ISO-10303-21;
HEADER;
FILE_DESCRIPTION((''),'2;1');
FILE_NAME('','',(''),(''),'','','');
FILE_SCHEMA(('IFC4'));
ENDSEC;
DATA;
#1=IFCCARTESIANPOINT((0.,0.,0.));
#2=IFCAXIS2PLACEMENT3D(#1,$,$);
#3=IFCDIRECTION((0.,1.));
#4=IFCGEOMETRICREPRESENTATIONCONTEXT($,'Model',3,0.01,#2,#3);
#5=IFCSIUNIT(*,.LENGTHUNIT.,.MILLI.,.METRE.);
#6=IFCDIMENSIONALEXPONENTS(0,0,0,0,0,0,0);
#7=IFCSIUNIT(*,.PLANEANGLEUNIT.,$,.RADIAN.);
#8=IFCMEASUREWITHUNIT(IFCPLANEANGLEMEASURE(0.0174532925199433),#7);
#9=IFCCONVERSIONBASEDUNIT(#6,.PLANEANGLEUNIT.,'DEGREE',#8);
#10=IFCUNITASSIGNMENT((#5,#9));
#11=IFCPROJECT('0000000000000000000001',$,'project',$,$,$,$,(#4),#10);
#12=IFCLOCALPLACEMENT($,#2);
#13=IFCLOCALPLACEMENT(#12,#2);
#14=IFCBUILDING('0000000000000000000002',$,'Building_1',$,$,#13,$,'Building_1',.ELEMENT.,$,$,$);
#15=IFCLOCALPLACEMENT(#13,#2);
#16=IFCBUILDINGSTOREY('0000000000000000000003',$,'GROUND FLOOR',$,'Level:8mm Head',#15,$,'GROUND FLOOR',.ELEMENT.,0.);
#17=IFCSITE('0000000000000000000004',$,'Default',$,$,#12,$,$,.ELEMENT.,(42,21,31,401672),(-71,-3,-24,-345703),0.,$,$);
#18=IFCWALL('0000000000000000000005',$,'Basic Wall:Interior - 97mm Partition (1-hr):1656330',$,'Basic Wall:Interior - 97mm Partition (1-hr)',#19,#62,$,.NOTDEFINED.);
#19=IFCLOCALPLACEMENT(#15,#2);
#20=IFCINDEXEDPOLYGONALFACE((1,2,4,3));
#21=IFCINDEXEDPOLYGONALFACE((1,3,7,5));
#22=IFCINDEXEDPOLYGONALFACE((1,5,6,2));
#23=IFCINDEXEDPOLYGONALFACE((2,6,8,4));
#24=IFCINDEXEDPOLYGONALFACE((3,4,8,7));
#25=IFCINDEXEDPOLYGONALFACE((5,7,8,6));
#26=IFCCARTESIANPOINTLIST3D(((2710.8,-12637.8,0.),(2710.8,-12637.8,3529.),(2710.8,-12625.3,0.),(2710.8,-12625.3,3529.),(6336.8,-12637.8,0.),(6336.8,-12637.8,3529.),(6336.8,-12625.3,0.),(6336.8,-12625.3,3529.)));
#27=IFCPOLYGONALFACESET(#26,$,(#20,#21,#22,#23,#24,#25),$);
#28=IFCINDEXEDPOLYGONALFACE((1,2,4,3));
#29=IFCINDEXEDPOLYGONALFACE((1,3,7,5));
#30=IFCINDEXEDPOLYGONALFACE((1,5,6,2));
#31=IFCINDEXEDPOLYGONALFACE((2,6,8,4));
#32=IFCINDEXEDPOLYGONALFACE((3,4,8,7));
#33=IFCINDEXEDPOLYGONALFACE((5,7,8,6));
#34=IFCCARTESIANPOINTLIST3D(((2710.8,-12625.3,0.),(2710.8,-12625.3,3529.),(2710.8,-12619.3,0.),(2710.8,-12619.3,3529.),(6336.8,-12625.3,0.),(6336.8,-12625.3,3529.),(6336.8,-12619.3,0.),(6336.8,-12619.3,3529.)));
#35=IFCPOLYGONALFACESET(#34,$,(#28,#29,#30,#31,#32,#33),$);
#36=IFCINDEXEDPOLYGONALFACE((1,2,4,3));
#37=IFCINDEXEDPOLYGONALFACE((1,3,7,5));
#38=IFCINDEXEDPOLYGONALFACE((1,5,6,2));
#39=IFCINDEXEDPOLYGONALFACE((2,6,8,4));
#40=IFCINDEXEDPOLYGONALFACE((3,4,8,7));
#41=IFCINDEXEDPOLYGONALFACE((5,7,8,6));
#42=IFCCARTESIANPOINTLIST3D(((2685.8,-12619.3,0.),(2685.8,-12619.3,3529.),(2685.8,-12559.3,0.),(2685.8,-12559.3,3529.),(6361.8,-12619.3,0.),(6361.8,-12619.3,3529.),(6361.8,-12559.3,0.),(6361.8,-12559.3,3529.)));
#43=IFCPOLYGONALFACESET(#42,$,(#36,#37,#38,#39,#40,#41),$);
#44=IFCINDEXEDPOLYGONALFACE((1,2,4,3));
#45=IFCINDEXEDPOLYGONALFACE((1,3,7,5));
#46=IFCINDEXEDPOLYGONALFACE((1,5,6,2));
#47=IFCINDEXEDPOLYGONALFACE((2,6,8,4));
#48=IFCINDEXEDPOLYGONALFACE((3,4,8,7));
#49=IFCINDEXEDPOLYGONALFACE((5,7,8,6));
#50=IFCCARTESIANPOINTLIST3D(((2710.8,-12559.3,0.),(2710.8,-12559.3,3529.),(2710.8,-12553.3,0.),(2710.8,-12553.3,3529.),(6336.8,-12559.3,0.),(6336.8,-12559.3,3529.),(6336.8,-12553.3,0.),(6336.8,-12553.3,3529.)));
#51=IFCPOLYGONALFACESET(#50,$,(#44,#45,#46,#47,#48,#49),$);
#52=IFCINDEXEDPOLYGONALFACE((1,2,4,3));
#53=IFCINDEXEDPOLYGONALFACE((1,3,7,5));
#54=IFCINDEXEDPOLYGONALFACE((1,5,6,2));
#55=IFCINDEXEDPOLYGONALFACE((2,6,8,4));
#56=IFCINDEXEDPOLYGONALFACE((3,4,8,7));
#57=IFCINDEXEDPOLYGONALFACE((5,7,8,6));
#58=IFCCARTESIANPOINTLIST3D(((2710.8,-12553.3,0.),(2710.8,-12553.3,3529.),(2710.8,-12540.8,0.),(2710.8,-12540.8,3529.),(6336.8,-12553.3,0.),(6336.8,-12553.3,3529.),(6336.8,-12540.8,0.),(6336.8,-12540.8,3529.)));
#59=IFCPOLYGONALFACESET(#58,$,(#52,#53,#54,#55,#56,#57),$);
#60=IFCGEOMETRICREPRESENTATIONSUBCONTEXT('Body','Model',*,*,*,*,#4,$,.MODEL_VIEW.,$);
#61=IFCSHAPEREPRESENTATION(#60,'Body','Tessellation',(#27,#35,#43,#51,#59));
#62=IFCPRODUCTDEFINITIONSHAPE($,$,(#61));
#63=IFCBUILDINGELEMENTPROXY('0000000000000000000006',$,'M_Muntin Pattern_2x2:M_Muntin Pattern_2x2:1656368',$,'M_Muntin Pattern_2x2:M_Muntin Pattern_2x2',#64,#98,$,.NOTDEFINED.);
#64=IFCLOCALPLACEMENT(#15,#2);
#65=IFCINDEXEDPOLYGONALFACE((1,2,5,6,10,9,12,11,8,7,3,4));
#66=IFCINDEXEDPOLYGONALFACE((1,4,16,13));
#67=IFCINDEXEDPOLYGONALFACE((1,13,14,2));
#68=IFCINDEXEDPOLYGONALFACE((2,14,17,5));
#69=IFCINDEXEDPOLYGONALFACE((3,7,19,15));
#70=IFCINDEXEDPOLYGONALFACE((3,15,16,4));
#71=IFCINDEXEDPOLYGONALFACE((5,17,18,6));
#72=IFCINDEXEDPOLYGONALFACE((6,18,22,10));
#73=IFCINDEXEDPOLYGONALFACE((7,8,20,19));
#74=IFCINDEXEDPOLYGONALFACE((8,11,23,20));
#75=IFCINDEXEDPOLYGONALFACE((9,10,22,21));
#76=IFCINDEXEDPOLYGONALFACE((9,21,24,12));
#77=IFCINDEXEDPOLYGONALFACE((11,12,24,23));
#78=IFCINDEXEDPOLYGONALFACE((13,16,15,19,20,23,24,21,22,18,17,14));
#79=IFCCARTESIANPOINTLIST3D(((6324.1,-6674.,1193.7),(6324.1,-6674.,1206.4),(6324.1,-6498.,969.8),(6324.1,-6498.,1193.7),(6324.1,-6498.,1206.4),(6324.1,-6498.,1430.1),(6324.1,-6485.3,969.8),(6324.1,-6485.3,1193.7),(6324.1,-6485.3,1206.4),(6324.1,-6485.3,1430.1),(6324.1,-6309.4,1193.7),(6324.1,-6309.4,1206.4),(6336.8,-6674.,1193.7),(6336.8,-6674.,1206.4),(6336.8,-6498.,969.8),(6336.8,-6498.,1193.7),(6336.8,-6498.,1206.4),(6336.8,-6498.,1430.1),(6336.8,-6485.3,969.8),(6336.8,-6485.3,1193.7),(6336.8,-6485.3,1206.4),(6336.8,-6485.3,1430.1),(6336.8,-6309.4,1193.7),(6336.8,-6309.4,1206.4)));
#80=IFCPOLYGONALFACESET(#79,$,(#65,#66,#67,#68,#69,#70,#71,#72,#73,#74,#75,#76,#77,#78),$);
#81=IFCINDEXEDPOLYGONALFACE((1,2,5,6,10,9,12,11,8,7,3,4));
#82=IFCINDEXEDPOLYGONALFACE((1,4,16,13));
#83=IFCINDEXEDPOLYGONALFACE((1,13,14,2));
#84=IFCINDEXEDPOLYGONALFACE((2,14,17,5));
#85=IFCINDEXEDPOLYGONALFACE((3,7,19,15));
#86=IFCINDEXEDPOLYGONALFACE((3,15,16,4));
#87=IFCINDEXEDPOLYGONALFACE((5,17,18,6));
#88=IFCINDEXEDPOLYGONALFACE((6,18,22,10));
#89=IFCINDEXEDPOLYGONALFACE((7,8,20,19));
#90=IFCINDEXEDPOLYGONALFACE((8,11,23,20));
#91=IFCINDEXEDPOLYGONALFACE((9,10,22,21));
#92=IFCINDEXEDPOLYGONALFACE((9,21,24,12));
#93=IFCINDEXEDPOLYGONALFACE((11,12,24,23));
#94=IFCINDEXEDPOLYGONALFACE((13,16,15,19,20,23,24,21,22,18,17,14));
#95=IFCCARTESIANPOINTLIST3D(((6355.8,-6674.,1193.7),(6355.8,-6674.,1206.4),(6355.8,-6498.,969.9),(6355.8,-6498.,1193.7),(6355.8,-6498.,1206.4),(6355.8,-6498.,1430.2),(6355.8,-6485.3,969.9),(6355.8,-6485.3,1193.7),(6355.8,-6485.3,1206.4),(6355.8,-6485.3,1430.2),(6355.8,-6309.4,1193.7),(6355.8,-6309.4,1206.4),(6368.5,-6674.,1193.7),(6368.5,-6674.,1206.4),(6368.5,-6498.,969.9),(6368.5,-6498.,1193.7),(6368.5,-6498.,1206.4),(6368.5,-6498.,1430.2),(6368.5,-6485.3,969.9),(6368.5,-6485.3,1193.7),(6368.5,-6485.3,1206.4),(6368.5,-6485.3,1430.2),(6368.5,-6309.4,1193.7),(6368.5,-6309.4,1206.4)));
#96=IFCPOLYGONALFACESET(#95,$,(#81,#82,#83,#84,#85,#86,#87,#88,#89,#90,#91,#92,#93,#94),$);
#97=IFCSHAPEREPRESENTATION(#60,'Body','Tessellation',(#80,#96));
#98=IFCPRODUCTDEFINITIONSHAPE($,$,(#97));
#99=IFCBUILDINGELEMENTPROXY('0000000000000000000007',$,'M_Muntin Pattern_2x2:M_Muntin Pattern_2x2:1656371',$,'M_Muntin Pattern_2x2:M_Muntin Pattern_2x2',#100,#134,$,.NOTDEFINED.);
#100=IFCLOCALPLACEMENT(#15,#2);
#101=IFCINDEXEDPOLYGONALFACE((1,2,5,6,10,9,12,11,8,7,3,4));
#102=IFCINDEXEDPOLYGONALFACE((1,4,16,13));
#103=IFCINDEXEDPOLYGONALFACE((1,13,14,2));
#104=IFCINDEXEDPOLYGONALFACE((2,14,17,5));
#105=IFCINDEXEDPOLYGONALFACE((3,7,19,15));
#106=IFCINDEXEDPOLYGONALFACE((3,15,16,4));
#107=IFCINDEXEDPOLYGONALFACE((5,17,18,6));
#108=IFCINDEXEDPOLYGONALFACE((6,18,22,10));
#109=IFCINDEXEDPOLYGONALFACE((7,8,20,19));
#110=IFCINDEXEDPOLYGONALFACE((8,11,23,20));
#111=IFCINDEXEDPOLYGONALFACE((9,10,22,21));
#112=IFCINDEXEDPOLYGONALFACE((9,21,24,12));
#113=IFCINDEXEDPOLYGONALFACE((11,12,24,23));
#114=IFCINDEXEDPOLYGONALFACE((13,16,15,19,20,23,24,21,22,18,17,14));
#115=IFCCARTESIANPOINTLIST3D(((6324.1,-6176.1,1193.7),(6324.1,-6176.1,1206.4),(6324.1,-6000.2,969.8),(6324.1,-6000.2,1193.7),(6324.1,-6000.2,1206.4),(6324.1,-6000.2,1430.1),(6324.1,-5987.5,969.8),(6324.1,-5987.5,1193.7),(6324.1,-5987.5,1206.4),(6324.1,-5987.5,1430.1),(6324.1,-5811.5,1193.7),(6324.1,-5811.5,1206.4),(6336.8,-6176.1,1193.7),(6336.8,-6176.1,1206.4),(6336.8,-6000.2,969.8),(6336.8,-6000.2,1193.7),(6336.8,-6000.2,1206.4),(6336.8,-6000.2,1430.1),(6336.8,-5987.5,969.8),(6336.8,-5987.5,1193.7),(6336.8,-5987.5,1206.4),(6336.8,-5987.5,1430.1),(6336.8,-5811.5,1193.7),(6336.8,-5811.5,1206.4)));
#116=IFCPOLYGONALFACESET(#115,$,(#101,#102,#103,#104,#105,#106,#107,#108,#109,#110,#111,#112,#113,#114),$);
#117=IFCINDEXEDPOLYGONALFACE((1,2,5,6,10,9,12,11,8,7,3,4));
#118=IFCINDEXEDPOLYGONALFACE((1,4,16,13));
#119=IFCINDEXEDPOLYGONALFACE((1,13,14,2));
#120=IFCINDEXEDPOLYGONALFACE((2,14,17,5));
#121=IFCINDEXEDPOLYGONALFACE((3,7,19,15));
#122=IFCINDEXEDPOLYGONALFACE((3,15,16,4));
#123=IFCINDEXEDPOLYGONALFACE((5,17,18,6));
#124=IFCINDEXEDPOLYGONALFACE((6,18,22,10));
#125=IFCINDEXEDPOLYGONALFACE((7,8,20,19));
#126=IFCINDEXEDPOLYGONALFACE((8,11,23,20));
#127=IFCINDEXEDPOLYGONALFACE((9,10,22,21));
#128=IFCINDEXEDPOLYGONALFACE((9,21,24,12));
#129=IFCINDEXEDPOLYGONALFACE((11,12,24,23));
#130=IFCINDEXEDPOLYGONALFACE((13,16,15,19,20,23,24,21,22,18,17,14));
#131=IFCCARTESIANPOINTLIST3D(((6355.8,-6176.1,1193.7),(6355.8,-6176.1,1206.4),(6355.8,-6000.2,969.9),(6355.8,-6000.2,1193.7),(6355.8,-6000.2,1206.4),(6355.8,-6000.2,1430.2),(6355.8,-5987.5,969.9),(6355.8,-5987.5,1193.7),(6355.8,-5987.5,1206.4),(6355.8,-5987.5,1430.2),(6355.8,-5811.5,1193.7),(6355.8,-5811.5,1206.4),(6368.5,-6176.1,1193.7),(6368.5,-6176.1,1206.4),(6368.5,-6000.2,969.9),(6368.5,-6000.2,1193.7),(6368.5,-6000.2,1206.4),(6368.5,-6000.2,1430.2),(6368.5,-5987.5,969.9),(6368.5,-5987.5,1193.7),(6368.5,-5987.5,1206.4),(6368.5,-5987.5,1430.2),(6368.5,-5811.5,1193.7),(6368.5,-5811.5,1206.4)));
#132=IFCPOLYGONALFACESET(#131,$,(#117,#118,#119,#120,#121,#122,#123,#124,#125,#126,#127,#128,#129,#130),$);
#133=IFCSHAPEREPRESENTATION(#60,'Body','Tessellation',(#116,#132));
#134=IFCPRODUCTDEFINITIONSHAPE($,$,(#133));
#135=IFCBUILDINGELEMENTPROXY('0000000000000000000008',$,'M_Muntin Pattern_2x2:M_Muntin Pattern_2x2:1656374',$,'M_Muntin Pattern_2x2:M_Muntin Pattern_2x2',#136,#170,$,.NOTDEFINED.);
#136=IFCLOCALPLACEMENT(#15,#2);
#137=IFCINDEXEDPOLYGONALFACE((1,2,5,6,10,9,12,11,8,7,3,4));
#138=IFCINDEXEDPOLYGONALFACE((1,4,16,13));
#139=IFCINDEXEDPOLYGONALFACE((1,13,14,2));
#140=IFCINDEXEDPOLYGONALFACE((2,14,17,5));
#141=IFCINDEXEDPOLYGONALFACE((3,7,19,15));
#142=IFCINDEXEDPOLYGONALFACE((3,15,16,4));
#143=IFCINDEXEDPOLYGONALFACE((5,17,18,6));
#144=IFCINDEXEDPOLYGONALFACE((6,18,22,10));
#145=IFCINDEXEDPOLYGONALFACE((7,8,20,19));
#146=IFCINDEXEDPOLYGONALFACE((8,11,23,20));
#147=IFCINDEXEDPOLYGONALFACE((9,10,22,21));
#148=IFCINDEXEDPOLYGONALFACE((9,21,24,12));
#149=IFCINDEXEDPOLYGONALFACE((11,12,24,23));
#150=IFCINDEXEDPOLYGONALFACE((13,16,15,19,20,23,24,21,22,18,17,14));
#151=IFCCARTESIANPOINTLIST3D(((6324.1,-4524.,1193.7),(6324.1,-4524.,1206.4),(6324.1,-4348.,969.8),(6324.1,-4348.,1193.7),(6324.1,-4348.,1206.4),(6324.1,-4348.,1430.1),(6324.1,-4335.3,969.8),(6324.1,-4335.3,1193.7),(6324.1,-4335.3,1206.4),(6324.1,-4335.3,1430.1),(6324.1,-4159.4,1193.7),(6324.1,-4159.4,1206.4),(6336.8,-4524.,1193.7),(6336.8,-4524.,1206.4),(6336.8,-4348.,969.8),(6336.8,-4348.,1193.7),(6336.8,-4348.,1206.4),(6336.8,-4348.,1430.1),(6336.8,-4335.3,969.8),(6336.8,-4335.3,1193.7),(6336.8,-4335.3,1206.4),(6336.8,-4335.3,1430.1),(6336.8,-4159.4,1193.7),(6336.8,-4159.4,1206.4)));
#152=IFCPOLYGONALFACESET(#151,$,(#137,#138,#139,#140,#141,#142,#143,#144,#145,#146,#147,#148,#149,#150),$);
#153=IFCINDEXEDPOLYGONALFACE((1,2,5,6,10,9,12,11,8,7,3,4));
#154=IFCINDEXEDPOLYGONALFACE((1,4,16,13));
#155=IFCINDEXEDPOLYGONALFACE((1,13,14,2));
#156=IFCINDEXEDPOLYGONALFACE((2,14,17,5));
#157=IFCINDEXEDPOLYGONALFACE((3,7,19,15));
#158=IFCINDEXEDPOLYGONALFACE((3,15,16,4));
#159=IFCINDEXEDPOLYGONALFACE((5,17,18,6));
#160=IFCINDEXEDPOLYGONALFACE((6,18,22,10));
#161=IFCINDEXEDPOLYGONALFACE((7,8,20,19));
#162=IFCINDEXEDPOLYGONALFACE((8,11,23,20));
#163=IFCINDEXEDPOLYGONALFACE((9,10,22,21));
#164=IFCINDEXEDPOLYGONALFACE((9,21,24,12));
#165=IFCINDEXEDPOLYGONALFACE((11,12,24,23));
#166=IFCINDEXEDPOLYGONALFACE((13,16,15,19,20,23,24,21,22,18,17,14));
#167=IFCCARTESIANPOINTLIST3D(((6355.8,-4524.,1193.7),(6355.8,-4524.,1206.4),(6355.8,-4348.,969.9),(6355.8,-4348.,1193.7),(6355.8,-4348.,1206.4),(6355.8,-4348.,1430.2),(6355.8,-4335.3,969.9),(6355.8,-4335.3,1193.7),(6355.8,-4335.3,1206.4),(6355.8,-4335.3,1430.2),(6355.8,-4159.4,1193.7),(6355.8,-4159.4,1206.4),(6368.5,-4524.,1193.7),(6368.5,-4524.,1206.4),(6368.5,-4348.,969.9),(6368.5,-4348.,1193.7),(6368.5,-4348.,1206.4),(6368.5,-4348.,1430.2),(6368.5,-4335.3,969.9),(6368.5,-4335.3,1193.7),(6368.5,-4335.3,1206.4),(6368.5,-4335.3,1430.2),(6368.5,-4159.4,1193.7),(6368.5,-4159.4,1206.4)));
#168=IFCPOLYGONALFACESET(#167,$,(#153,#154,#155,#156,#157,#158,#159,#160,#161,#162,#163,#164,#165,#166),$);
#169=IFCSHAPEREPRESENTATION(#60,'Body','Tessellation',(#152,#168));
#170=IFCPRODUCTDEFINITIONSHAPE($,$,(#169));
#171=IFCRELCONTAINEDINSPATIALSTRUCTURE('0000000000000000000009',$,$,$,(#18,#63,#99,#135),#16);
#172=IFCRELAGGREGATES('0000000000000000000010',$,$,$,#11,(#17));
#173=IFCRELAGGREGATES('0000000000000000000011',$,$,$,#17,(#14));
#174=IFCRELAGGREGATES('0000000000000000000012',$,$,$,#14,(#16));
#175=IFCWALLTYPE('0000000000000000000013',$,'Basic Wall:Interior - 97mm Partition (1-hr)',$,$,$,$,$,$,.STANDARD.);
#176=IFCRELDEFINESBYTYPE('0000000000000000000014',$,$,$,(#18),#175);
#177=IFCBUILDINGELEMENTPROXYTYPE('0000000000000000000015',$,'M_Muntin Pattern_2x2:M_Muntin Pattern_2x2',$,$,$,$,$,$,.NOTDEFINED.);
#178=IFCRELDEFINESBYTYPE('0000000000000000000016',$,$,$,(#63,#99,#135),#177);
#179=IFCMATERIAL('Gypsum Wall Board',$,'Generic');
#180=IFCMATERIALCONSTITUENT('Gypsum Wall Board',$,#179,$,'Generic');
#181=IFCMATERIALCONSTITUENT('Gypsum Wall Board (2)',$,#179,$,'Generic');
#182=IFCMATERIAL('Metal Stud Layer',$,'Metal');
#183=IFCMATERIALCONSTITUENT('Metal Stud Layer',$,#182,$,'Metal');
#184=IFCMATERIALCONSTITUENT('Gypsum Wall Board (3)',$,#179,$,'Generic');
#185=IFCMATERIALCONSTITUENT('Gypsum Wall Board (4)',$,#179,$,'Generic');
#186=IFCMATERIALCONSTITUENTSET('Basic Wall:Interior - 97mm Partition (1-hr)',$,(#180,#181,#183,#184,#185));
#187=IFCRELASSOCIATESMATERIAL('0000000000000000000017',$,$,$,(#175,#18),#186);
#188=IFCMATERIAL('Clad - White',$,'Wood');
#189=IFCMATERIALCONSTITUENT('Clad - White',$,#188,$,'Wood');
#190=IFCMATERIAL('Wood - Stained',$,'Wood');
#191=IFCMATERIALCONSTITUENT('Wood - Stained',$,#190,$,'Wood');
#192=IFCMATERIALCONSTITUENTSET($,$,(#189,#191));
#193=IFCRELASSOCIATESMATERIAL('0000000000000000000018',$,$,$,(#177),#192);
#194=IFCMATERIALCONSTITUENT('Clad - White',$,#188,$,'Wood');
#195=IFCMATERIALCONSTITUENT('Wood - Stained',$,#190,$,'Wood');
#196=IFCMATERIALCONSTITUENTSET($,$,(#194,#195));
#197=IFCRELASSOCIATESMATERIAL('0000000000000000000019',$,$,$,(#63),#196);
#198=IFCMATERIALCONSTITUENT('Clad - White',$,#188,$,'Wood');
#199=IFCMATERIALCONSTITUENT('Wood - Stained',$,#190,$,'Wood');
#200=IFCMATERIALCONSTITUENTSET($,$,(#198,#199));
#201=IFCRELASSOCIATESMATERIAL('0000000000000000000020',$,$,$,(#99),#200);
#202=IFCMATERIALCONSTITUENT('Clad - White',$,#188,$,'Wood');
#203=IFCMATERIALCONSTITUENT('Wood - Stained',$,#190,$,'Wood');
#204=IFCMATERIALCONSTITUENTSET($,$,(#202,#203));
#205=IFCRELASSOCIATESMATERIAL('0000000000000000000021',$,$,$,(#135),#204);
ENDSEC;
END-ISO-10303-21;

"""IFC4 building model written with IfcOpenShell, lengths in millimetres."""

from ifc_helpers import new_model, entity, si_unit, converted_unit, direction, frame, origin, place, context, subcontext, project, spatial, indexed_curve, outline, extrude, source, transform, mapped, material, constituent, constituent_set, type_object, type_shapes, element, save


model = new_model("IFC4")

# Units and contexts
model_context = context("Model", 3, precision=0.01, world=origin(), true_north=direction((0.0, 1.0)))
body_context = subcontext(model_context, "Body", "Model", "MODEL_VIEW")
ifc_project = project(units=[si_unit("LENGTHUNIT", "METRE", prefix="MILLI"), converted_unit("PLANEANGLEUNIT", "DEGREE", entity("IfcPlaneAngleMeasure", 0.0174532925199433), si_unit("PLANEANGLEUNIT", "RADIAN"), dimensions=[0, 0, 0, 0, 0, 0, 0])], contexts=[model_context])

# Site, building, storey
site_placement = place(None, origin())
site = spatial("IfcSite", under=ifc_project, at=site_placement, Name="Default", CompositionType="ELEMENT", RefLatitude=(42, 21, 31, 401672), RefLongitude=(-71, -3, -24, -345703), RefElevation=0.0)
building_placement = place(site_placement, origin())
building = spatial("IfcBuilding", under=site, at=building_placement, Name="Building_1", LongName="Building_1", CompositionType="ELEMENT")
storey_placement = place(building_placement, origin())
storey = spatial("IfcBuildingStorey", under=building, at=storey_placement, Name="GROUND FLOOR", ObjectType="Level:8mm Head", LongName="GROUND FLOOR", CompositionType="ELEMENT", Elevation=0.0)

# Shared definitions
ifc_material_1 = material(Name="Wood - Stained", Category="Wood")

# Wall
ifc_material_2 = material(Name="Gypsum Wall Board", Category="Generic")
ifc_constituent_1 = constituent(ifc_material_2, Name="Gypsum Wall Board", Category="Generic")
ifc_constituent_2 = constituent(ifc_material_2, Name="Gypsum Wall Board (2)", Category="Generic")
ifc_material_3 = material(Name="Metal Stud Layer", Category="Metal")
ifc_constituent_3 = constituent(ifc_material_3, Name="Metal Stud Layer", Category="Metal")
ifc_constituent_4 = constituent(ifc_material_2, Name="Gypsum Wall Board (3)", Category="Generic")
ifc_constituent_5 = constituent(ifc_material_2, Name="Gypsum Wall Board (4)", Category="Generic")
ifc_constituent_set_1 = constituent_set(constituents=[ifc_constituent_1, ifc_constituent_2, ifc_constituent_3, ifc_constituent_4, ifc_constituent_5], Name="Basic Wall:Interior - 97mm Partition (1-hr)")
wall_type_1 = type_object("IfcWallType", Name="Basic Wall:Interior - 97mm Partition (1-hr)", PredefinedType="STANDARD", material=ifc_constituent_set_1)
wall_1_placement = place(storey_placement, frame((6336.8, -12589.3, 0.0), z_axis=(0.0, 0.0, 1.0), x_axis=(-1.0, 0.0, 0.0)))
element("IfcWall", 1, at=wall_1_placement, inside=storey, type_object=wall_type_1, material=ifc_constituent_set_1, Name="Basic Wall:Interior - 97mm Partition (1-hr):1656330", ObjectType="Basic Wall:Interior - 97mm Partition (1-hr)", PredefinedType="NOTDEFINED", context=body_context, shape_type="SweptSolid", body=[
    extrude(outline(indexed_curve([(-6.2, -1764.5), (6.3, -1764.5), (6.2, 1764.5), (-6.2, 1764.5), (-6.2, -1764.5)], self_intersect=False)), frame((3626.0, 42.2, 1764.5), z_axis=(-1.0, 0.0, 0.0), x_axis=(0.0, -1.0, 0.0)), (0.0, 0.0, 1.0), 3626.0),
    extrude(outline(indexed_curve([(-1764.5, -3.0), (1764.5, -3.0), (1764.5, 3.0), (-1764.5, 3.0), (-1764.5, -3.0)], self_intersect=False)), frame((3626.0, 33.0, 1764.5), z_axis=(-1.0, 0.0, 0.0), x_axis=(0.0, 0.0, 1.0)), (0.0, 0.0, 1.0), 3626.0),
    extrude(outline(indexed_curve([(-1764.5, -30.0), (1764.5, -30.0), (1764.5, 30.0), (-1764.5, 30.0), (-1764.5, -30.0)], self_intersect=False)), frame((3651.0, 0.0, 1764.5), z_axis=(-1.0, 0.0, 0.0), x_axis=(0.0, 0.0, 1.0)), (0.0, 0.0, 1.0), 3676.0),
    extrude(outline(indexed_curve([(-1764.5, -3.0), (1764.5, -3.0), (1764.5, 3.0), (-1764.5, 3.0), (-1764.5, -3.0)], self_intersect=False)), frame((3626.0, -33.0, 1764.5), z_axis=(-1.0, 0.0, 0.0), x_axis=(0.0, 0.0, 1.0)), (0.0, 0.0, 1.0), 3626.0),
    extrude(outline(indexed_curve([(-6.3, -1764.5), (6.2, -1764.5), (6.2, 1764.5), (-6.3, 1764.5), (-6.3, -1764.5)], self_intersect=False)), frame((3626.0, -42.3, 1764.5), z_axis=(-1.0, 0.0, 0.0), x_axis=(0.0, 1.0, 0.0)), (0.0, 0.0, 1.0), 3626.0),
])

# Building element proxies
ifc_material_4 = material(Name="Clad - White", Category="Wood")
ifc_constituent_6 = constituent(ifc_material_4, Name="Clad - White", Category="Wood")
ifc_constituent_7 = constituent(ifc_material_1, Name="Wood - Stained", Category="Wood")
ifc_constituent_set_2 = constituent_set(constituents=[ifc_constituent_6, ifc_constituent_7])
ifc_constituent_8 = constituent(ifc_material_4, Name="Clad - White", Category="Wood")
ifc_constituent_9 = constituent(ifc_material_1, Name="Wood - Stained", Category="Wood")
ifc_constituent_set_3 = constituent_set(constituents=[ifc_constituent_8, ifc_constituent_9])
building_element_proxy_type_1 = type_object("IfcBuildingElementProxyType", Name="M_Muntin Pattern_2x2:M_Muntin Pattern_2x2", PredefinedType="NOTDEFINED", material=ifc_constituent_set_3)
shared_shape_1 = source(origin(), body_context, "Body", "SweptSolid", [
    extrude(outline(indexed_curve([(6.4, -6.4), (230.1, -6.4), (230.1, 6.3), (6.4, 6.3), (6.4, 182.3), (-6.3, 182.3), (-6.3, 6.3), (-230.2, 6.3), (-230.2, -6.4), (-6.3, -6.4), (-6.3, -182.3), (6.4, -182.3), (6.4, -6.4)], self_intersect=False)), frame((0.0, 9.5, 230.1), z_axis=(0.0, 1.0, 0.0), x_axis=(0.0, 0.0, 1.0)), (0.0, 0.0, 1.0), 12.7),
    extrude(outline(indexed_curve([(6.4, -6.4), (230.2, -6.4), (230.2, 6.3), (6.4, 6.3), (6.4, 182.3), (-6.3, 182.3), (-6.3, 6.3), (-230.2, 6.3), (-230.2, -6.4), (-6.3, -6.4), (-6.3, -182.3), (6.4, -182.3), (6.4, -6.4)], self_intersect=False)), frame((0.0, -22.2, 230.2), z_axis=(0.0, 1.0, 0.0), x_axis=(0.0, 0.0, 1.0)), (0.0, 0.0, 1.0), 12.7),
])
type_shapes(building_element_proxy_type_1, [shared_shape_1])
proxy_1_placement = place(storey_placement, frame((6346.3, -6491.7, 969.9), z_axis=(0.0, 0.0, 1.0), x_axis=(0.0, 1.0, 0.0)))
element("IfcBuildingElementProxy", 2, at=proxy_1_placement, inside=storey, type_object=building_element_proxy_type_1, material=ifc_constituent_set_2, Name="M_Muntin Pattern_2x2:M_Muntin Pattern_2x2:1656368", ObjectType="M_Muntin Pattern_2x2:M_Muntin Pattern_2x2", PredefinedType="NOTDEFINED", context=body_context, shape_type="MappedRepresentation", body=[
    mapped(shared_shape_1, transform((0.0, 0.0, 0.0), scale=1.0)),
])
ifc_constituent_10 = constituent(ifc_material_4, Name="Clad - White", Category="Wood")
ifc_constituent_11 = constituent(ifc_material_1, Name="Wood - Stained", Category="Wood")
ifc_constituent_set_4 = constituent_set(constituents=[ifc_constituent_10, ifc_constituent_11])
proxy_2_placement = place(storey_placement, frame((6346.3, -5993.8, 969.9), z_axis=(0.0, 0.0, 1.0), x_axis=(0.0, 1.0, 0.0)))
element("IfcBuildingElementProxy", 3, at=proxy_2_placement, inside=storey, type_object=building_element_proxy_type_1, material=ifc_constituent_set_4, Name="M_Muntin Pattern_2x2:M_Muntin Pattern_2x2:1656371", ObjectType="M_Muntin Pattern_2x2:M_Muntin Pattern_2x2", PredefinedType="NOTDEFINED", context=body_context, shape_type="MappedRepresentation", body=[
    mapped(shared_shape_1, transform((0.0, 0.0, 0.0), scale=1.0)),
])
ifc_constituent_12 = constituent(ifc_material_4, Name="Clad - White", Category="Wood")
ifc_constituent_13 = constituent(ifc_material_1, Name="Wood - Stained", Category="Wood")
ifc_constituent_set_5 = constituent_set(constituents=[ifc_constituent_12, ifc_constituent_13])
proxy_3_placement = place(storey_placement, frame((6346.3, -4341.7, 969.9), z_axis=(0.0, 0.0, 1.0), x_axis=(0.0, 1.0, 0.0)))
element("IfcBuildingElementProxy", 4, at=proxy_3_placement, inside=storey, type_object=building_element_proxy_type_1, material=ifc_constituent_set_5, Name="M_Muntin Pattern_2x2:M_Muntin Pattern_2x2:1656374", ObjectType="M_Muntin Pattern_2x2:M_Muntin Pattern_2x2", PredefinedType="NOTDEFINED", context=body_context, shape_type="MappedRepresentation", body=[
    mapped(shared_shape_1, transform((0.0, 0.0, 0.0), scale=1.0)),
])

save(model, "model.ifc")
